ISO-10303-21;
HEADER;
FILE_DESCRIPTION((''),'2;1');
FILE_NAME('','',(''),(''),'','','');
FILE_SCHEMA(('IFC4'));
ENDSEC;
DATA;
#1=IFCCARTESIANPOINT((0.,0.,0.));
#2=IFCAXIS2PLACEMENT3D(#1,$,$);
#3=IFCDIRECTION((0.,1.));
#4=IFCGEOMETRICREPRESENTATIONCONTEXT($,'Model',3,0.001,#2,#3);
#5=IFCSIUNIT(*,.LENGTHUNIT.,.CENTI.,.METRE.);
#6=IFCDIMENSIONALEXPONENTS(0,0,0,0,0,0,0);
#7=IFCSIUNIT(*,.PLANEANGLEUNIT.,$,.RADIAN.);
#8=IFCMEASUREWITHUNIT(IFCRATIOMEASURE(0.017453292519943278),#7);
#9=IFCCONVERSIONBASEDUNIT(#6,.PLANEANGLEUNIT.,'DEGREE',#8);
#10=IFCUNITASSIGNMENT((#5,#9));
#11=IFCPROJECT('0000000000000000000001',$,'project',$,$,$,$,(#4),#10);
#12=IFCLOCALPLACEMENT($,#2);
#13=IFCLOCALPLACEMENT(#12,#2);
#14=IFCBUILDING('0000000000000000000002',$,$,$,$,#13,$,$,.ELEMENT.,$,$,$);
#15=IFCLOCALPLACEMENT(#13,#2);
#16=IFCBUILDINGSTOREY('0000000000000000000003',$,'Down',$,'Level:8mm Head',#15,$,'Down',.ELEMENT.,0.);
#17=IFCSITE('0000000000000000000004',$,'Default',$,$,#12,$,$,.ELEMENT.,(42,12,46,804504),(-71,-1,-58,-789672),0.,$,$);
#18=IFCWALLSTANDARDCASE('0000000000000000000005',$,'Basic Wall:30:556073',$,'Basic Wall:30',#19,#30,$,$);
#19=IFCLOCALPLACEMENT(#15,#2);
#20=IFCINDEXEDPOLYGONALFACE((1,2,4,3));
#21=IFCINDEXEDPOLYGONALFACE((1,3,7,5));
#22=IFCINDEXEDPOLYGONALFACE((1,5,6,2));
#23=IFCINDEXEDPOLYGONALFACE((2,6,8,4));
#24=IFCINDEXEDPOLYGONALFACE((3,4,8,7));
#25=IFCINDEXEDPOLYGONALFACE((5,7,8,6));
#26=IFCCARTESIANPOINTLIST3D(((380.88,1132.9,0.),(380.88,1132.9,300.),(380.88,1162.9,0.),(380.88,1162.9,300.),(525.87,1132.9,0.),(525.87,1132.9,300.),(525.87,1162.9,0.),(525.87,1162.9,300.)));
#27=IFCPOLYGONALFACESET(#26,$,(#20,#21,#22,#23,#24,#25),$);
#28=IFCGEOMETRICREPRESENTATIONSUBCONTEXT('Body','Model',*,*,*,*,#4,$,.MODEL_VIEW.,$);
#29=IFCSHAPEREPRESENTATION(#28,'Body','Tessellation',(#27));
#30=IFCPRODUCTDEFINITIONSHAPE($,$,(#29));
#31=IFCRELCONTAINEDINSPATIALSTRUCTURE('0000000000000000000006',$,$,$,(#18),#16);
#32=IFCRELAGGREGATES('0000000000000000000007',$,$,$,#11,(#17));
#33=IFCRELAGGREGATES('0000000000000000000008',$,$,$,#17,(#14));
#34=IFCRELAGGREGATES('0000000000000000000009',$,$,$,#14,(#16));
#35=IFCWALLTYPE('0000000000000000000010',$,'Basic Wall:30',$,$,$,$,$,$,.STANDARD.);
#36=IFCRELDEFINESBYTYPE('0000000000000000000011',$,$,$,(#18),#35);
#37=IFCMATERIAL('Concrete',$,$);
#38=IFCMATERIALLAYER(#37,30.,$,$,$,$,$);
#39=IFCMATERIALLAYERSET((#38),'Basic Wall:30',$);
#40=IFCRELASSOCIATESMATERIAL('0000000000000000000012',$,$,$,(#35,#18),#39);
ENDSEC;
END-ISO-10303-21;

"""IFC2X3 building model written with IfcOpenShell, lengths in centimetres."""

from ifc_helpers import new_model, entity, si_unit, converted_unit, direction, frame, frame_2d, origin, place, context, subcontext, project, spatial, rectangle, extrude, material, layer, layer_set, layer_usage, type_object, element, save


model = new_model("IFC2X3")

# Units and contexts
model_context = context("Model", 3, precision=0.001, world=origin(), true_north=direction((0.0, 1.0)))
body_context = subcontext(model_context, "Body", "Model", "MODEL_VIEW")
ifc_project = project(units=[si_unit("LENGTHUNIT", "METRE", prefix="CENTI"), converted_unit("PLANEANGLEUNIT", "DEGREE", entity("IfcRatioMeasure", 0.017453292519943278), si_unit("PLANEANGLEUNIT", "RADIAN"), dimensions=[0, 0, 0, 0, 0, 0, 0])], contexts=[model_context])

# Site, building, storey
site_placement = place(None, origin())
site = spatial("IfcSite", under=ifc_project, at=site_placement, Name="Default", CompositionType="ELEMENT", RefLatitude=(42, 12, 46, 804504), RefLongitude=(-71, -1, -58, -789672), RefElevation=0.0)
building_placement = place(site_placement, origin())
building = spatial("IfcBuilding", under=site, at=building_placement, CompositionType="ELEMENT")
storey_placement = place(building_placement, origin())
storey = spatial("IfcBuildingStorey", under=building, at=storey_placement, Name="Down", ObjectType="Level:8mm Head", LongName="Down", CompositionType="ELEMENT", Elevation=0.0)

# Wall
ifc_material = material(Name="Concrete")
ifc_layer_1 = layer(ifc_material, 30.0)
ifc_layer_set_1 = layer_set([ifc_layer_1], Name="Basic Wall:30")
wall_type_1 = type_object("IfcWallType", Name="Basic Wall:30", PredefinedType="STANDARD", material=ifc_layer_set_1)
ifc_layer_usage_1 = layer_usage(ifc_layer_set_1, "AXIS2", "NEGATIVE", 15.0)
wall_1_placement = place(storey_placement, frame((525.87, 1147.9, 0.0), z_axis=(0.0, 0.0, 1.0), x_axis=(-1.0, 0.0, 0.0)))
element("IfcWallStandardCase", 1, at=wall_1_placement, inside=storey, type_object=wall_type_1, material=ifc_layer_usage_1, Name="Basic Wall:30:556073", ObjectType="Basic Wall:30", context=body_context, shape_type="SweptSolid", body=[
    extrude(rectangle(XDim=144.99, YDim=30.0, at=frame_2d((72.5, 0.0), x_axis=(-1.0, 0.0))), origin(), (0.0, 0.0, 1.0), 300.0),
])

save(model, "model.ifc")
